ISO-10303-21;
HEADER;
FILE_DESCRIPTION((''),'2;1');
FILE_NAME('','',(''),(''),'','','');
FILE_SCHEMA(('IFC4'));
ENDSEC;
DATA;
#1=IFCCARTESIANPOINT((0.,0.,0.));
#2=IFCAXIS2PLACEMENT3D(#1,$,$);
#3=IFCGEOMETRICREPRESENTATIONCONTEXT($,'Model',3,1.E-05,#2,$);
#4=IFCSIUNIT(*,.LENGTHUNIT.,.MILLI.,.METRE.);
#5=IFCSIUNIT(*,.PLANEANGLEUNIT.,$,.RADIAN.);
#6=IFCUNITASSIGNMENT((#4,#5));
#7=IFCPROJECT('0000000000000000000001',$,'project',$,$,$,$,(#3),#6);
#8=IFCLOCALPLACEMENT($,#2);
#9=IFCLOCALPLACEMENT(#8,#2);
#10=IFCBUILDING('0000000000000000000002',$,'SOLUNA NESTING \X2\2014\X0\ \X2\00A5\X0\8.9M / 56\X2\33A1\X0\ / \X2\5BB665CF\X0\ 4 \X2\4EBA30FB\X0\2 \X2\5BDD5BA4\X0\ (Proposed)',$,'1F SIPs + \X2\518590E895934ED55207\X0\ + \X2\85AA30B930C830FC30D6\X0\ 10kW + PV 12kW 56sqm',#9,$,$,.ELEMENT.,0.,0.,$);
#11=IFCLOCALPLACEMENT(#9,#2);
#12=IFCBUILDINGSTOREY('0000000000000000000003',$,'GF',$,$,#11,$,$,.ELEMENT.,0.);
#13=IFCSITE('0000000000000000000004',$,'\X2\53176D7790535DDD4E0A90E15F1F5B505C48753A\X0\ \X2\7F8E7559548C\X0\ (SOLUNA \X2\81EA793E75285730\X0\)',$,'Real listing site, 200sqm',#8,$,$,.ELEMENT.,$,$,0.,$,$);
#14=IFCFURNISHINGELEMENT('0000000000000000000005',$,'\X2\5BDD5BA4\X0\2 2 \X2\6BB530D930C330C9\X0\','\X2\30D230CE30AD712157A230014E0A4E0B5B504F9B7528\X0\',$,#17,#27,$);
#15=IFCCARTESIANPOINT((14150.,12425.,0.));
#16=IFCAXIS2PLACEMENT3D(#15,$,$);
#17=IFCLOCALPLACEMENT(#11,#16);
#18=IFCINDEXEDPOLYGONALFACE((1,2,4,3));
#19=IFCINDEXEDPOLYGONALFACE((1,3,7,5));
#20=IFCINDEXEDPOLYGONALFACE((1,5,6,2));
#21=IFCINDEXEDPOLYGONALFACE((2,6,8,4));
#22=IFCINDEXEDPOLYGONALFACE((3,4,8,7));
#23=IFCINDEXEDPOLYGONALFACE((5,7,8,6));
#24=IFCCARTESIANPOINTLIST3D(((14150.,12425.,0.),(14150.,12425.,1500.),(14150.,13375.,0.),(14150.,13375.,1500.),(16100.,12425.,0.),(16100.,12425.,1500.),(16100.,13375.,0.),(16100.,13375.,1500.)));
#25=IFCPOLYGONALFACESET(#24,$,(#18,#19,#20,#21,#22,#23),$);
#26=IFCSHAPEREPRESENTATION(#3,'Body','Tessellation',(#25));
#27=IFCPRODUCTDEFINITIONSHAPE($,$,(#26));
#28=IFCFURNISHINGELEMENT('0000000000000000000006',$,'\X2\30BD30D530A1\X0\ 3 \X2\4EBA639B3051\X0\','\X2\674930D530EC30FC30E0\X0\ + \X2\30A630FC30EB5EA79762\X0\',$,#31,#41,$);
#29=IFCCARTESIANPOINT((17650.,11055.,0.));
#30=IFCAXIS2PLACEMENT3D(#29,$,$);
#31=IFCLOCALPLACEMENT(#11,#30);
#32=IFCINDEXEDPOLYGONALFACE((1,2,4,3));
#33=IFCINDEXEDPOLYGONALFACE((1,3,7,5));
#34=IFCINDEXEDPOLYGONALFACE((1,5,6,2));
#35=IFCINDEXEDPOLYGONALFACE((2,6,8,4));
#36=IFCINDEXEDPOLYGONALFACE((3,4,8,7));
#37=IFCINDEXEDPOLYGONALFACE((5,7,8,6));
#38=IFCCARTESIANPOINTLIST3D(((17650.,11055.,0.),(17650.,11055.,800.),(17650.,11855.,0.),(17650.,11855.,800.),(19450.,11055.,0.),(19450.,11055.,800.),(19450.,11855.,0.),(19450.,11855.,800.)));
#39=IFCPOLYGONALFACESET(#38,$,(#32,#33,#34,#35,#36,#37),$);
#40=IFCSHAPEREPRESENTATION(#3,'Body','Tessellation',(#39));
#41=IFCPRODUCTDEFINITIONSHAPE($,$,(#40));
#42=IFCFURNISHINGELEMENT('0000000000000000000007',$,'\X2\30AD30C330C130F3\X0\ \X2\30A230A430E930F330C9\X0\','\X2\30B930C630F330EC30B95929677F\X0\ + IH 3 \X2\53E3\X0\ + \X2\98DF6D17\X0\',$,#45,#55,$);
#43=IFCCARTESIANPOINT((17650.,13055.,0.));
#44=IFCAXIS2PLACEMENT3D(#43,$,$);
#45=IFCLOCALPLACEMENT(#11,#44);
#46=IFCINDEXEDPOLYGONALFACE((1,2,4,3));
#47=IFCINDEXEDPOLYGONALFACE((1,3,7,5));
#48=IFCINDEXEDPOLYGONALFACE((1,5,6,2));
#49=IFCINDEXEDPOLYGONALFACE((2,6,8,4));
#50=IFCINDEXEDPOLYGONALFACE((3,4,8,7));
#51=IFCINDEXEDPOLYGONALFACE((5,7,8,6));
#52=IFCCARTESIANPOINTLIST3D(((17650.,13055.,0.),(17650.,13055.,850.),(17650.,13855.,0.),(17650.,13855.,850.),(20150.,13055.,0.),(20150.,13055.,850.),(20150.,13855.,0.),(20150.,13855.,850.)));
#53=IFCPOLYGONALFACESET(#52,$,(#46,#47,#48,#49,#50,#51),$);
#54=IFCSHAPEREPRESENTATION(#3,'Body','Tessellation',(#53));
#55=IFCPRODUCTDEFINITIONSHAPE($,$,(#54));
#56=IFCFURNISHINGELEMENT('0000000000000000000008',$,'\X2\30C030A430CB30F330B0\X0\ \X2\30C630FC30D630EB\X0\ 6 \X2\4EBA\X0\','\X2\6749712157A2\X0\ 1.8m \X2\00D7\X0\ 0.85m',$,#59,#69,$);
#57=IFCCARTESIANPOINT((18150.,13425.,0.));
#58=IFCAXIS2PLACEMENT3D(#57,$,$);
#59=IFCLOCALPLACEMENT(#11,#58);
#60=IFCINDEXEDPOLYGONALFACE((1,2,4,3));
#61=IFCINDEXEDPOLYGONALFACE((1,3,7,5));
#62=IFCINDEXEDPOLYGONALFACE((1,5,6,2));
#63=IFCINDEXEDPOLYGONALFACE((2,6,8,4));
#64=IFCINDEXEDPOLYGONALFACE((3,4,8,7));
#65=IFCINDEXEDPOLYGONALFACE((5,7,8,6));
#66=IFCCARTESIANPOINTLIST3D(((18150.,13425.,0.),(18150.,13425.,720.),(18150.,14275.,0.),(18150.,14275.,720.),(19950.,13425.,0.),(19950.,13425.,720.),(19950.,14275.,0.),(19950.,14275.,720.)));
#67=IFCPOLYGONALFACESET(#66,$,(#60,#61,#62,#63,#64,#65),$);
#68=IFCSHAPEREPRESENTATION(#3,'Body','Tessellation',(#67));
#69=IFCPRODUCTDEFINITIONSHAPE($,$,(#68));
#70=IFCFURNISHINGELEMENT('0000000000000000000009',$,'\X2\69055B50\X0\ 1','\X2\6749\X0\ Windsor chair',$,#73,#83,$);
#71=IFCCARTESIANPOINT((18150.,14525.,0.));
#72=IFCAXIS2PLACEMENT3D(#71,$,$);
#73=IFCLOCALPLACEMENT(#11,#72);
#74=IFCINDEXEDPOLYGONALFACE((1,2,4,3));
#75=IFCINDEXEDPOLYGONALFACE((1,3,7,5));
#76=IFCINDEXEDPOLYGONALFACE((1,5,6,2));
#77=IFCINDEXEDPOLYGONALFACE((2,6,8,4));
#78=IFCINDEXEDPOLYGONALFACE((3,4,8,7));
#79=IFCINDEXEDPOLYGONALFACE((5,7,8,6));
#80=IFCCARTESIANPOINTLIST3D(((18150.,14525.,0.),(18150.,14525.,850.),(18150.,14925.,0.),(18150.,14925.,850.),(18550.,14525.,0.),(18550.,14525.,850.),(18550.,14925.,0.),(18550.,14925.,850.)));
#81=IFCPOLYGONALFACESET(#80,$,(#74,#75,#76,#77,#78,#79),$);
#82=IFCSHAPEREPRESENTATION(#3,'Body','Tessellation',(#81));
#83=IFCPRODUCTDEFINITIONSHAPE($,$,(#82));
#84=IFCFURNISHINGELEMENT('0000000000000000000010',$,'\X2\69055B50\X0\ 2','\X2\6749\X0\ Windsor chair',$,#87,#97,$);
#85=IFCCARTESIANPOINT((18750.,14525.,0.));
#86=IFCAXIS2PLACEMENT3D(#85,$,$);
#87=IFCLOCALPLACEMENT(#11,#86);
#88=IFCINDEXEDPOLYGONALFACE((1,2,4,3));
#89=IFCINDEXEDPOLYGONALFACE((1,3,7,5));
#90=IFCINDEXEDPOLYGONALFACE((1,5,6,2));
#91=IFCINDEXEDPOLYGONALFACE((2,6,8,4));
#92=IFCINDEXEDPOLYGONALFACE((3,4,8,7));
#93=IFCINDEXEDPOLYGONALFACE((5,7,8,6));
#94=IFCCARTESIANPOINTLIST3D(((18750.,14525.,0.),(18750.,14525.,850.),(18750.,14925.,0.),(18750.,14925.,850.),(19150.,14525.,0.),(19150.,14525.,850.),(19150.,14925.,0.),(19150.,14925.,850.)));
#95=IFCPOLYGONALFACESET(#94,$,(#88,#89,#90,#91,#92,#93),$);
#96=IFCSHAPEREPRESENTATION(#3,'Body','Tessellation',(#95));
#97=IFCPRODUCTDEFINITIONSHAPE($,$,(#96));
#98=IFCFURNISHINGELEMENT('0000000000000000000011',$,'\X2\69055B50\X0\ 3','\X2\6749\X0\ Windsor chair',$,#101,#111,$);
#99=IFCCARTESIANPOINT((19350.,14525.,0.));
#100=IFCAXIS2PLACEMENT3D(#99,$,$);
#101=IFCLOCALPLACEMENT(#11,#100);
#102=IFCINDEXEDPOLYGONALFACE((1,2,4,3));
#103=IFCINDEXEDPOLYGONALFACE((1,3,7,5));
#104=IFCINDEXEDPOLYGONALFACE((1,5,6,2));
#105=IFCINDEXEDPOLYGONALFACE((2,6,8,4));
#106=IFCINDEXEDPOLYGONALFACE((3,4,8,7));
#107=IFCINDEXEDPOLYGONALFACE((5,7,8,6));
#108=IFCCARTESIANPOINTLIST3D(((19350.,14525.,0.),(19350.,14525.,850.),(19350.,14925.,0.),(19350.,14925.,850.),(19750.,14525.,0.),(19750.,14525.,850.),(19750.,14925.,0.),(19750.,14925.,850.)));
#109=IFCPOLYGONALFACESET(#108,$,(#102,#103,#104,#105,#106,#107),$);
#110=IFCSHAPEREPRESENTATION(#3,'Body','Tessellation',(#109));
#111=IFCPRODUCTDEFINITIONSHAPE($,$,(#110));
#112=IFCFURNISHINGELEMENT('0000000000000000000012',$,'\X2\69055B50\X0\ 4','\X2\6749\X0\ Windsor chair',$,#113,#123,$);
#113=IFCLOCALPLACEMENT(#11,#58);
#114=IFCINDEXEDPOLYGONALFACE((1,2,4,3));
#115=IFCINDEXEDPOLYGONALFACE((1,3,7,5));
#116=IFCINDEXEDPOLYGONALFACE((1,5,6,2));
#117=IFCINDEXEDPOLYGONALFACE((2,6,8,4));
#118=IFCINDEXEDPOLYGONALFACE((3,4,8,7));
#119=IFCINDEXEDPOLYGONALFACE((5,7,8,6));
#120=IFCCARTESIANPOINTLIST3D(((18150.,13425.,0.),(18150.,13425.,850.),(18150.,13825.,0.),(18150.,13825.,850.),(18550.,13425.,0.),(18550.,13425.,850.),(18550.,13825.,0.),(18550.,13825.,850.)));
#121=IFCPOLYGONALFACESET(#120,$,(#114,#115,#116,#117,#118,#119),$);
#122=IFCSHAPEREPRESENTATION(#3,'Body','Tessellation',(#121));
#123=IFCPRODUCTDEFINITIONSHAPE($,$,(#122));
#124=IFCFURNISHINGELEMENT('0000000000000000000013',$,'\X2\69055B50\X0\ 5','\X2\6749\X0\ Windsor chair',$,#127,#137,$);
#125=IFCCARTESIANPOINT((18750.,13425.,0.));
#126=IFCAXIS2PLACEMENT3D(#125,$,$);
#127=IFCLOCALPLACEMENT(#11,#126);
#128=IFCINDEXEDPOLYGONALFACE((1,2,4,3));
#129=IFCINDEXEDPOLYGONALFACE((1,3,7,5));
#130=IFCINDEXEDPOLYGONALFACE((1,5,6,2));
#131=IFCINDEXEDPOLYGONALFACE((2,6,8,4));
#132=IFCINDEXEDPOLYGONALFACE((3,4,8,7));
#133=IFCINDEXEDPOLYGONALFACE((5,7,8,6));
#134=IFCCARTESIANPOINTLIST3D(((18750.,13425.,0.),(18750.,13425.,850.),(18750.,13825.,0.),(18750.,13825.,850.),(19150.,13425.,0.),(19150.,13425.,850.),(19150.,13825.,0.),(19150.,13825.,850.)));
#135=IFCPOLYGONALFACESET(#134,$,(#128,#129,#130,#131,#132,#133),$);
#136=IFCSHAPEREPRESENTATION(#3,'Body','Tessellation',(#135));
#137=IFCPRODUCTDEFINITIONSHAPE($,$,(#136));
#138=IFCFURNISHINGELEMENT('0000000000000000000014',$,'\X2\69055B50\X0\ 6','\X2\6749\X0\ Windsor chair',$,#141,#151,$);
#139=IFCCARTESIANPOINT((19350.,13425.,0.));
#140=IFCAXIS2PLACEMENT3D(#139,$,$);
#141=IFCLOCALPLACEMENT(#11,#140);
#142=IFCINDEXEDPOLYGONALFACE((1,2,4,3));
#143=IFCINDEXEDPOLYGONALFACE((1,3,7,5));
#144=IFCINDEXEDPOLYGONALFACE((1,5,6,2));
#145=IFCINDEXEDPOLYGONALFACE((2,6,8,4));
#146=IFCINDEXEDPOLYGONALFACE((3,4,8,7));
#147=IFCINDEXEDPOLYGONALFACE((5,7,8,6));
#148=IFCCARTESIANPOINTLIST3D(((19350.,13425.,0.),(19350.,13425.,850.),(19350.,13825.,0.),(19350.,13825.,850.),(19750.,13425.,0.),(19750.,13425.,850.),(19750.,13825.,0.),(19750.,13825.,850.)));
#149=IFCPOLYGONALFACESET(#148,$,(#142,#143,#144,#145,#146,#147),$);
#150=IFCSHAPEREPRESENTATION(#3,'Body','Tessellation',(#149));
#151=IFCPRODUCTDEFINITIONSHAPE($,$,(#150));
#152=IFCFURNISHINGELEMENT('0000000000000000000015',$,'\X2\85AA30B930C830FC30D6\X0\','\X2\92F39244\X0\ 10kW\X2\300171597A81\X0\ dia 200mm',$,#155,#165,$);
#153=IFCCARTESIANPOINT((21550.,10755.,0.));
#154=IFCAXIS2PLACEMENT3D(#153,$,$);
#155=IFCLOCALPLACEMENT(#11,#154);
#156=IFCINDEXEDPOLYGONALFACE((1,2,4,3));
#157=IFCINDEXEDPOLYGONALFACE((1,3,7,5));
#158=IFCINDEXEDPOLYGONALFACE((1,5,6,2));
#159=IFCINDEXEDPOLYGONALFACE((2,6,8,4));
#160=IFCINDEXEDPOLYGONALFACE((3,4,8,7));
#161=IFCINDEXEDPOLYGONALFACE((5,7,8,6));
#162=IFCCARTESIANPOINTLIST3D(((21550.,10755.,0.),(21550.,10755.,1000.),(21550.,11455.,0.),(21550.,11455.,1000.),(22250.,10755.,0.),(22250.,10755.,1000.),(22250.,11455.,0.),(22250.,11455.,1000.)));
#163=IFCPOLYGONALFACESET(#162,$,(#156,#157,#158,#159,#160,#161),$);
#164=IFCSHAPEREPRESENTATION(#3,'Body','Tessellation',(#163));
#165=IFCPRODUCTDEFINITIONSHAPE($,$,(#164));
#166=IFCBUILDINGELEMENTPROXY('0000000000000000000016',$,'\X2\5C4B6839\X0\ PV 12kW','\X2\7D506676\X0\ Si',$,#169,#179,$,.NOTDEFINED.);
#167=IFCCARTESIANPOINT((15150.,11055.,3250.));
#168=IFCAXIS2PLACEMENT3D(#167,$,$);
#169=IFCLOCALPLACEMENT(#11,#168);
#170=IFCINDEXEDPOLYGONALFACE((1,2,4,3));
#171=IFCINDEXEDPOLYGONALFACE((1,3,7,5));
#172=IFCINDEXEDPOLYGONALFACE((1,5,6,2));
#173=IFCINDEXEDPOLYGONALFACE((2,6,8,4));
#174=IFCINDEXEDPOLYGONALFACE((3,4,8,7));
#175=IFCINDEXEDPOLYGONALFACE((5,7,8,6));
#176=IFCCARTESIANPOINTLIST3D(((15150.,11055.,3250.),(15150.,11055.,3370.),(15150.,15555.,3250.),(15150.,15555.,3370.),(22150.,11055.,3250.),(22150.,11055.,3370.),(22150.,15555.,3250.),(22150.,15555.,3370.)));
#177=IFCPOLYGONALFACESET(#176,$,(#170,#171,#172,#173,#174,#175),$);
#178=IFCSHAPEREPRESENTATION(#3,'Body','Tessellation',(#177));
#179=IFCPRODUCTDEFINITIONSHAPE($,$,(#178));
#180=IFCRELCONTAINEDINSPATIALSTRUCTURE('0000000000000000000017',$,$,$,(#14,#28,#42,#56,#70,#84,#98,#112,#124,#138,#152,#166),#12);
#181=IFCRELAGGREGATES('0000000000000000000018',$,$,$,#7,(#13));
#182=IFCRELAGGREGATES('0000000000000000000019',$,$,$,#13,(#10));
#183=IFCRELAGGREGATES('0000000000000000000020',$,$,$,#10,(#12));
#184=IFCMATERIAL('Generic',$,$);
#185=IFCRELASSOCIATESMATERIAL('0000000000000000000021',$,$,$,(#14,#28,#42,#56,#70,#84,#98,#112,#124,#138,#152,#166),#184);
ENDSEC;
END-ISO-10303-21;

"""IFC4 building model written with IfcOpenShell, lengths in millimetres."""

from ifc_helpers import new_model, si_unit, frame, frame_2d, origin, place, context, project, spatial, rectangle, extrude, material, element, save


model = new_model("IFC4")

# Units and contexts
model_context = context("Model", 3, precision=1e-05, world=origin())
ifc_project = project(units=[si_unit("LENGTHUNIT", "METRE", prefix="MILLI"), si_unit("PLANEANGLEUNIT", "RADIAN")], contexts=[model_context])

# Site, building, storey
site_placement = place(None, origin())
site = spatial("IfcSite", under=ifc_project, at=site_placement, Name="北海道川上郡弟子屈町 美留和 (SOLUNA 自社用地)", ObjectType="Real listing site, 200sqm", CompositionType="ELEMENT", RefElevation=0.0)
building_placement = place(site_placement, origin())
building = spatial("IfcBuilding", under=site, at=building_placement, Name="SOLUNA NESTING — ¥8.9M / 56㎡ / 家族 4 人・2 寝室 (Proposed)", ObjectType="1F SIPs + 内部間仕切 + 薪ストーブ 10kW + PV 12kW 56sqm", CompositionType="ELEMENT", ElevationOfRefHeight=0.0, ElevationOfTerrain=0.0)
storey_placement = place(building_placement, origin())
storey = spatial("IfcBuildingStorey", under=building, at=storey_placement, Name="GF", CompositionType="ELEMENT", Elevation=0.0)

# Shared definitions
ifc_material = material(Name="Generic")

# Furnishing elements
furnishing_1_placement = place(storey_placement, frame((14150.0, 12425.0, 0.0)))
element("IfcFurnishingElement", 1, at=furnishing_1_placement, inside=storey, material=ifc_material, Name="寝室2 2 段ベッド", Description="ヒノキ無垢、上下子供用", context=model_context, shape_type="SweptSolid", body=[
    extrude(rectangle(XDim=1950.0, YDim=950.0, at=frame_2d((975.0, 475.0))), frame((14150.0, 12425.0, 0.0)), (0.0, 0.0, 1.0), 1500.0),
])
furnishing_2_placement = place(storey_placement, frame((17650.0, 11055.0, 0.0)))
element("IfcFurnishingElement", 2, at=furnishing_2_placement, inside=storey, material=ifc_material, Name="ソファ 3 人掛け", Description="杉フレーム + ウール座面", context=model_context, shape_type="SweptSolid", body=[
    extrude(rectangle(XDim=1800.0, YDim=800.0, at=frame_2d((900.0, 400.0))), frame((17650.0, 11055.0, 0.0)), (0.0, 0.0, 1.0), 800.0),
])
furnishing_3_placement = place(storey_placement, frame((17650.0, 13055.0, 0.0)))
element("IfcFurnishingElement", 3, at=furnishing_3_placement, inside=storey, material=ifc_material, Name="キッチン アイランド", Description="ステンレス天板 + IH 3 口 + 食洗", context=model_context, shape_type="SweptSolid", body=[
    extrude(rectangle(XDim=2500.0, YDim=800.0, at=frame_2d((1250.0, 400.0))), frame((17650.0, 13055.0, 0.0)), (0.0, 0.0, 1.0), 850.0),
])
furnishing_4_placement = place(storey_placement, frame((18150.0, 13425.0, 0.0)))
element("IfcFurnishingElement", 4, at=furnishing_4_placement, inside=storey, material=ifc_material, Name="ダイニング テーブル 6 人", Description="杉無垢 1.8m × 0.85m", context=model_context, shape_type="SweptSolid", body=[
    extrude(rectangle(XDim=1800.0, YDim=850.0, at=frame_2d((900.0, 425.0))), frame((18150.0, 13425.0, 0.0)), (0.0, 0.0, 1.0), 720.0),
])
furnishing_5_placement = place(storey_placement, frame((18150.0, 14525.0, 0.0)))
element("IfcFurnishingElement", 5, at=furnishing_5_placement, inside=storey, material=ifc_material, Name="椅子 1", Description="杉 Windsor chair", context=model_context, shape_type="SweptSolid", body=[
    extrude(rectangle(XDim=400.0, YDim=400.0, at=frame_2d((200.0, 200.0))), frame((18150.0, 14525.0, 0.0)), (0.0, 0.0, 1.0), 850.0),
])
furnishing_6_placement = place(storey_placement, frame((18750.0, 14525.0, 0.0)))
element("IfcFurnishingElement", 6, at=furnishing_6_placement, inside=storey, material=ifc_material, Name="椅子 2", Description="杉 Windsor chair", context=model_context, shape_type="SweptSolid", body=[
    extrude(rectangle(XDim=400.0, YDim=400.0, at=frame_2d((200.0, 200.0))), frame((18750.0, 14525.0, 0.0)), (0.0, 0.0, 1.0), 850.0),
])
furnishing_7_placement = place(storey_placement, frame((19350.0, 14525.0, 0.0)))
element("IfcFurnishingElement", 7, at=furnishing_7_placement, inside=storey, material=ifc_material, Name="椅子 3", Description="杉 Windsor chair", context=model_context, shape_type="SweptSolid", body=[
    extrude(rectangle(XDim=400.0, YDim=400.0, at=frame_2d((200.0, 200.0))), frame((19350.0, 14525.0, 0.0)), (0.0, 0.0, 1.0), 850.0),
])
furnishing_8_placement = place(storey_placement, frame((18150.0, 13425.0, 0.0)))
element("IfcFurnishingElement", 8, at=furnishing_8_placement, inside=storey, material=ifc_material, Name="椅子 4", Description="杉 Windsor chair", context=model_context, shape_type="SweptSolid", body=[
    extrude(rectangle(XDim=400.0, YDim=400.0, at=frame_2d((200.0, 200.0))), frame((18150.0, 13425.0, 0.0)), (0.0, 0.0, 1.0), 850.0),
])
furnishing_9_placement = place(storey_placement, frame((18750.0, 13425.0, 0.0)))
element("IfcFurnishingElement", 9, at=furnishing_9_placement, inside=storey, material=ifc_material, Name="椅子 5", Description="杉 Windsor chair", context=model_context, shape_type="SweptSolid", body=[
    extrude(rectangle(XDim=400.0, YDim=400.0, at=frame_2d((200.0, 200.0))), frame((18750.0, 13425.0, 0.0)), (0.0, 0.0, 1.0), 850.0),
])
furnishing_10_placement = place(storey_placement, frame((19350.0, 13425.0, 0.0)))
element("IfcFurnishingElement", 10, at=furnishing_10_placement, inside=storey, material=ifc_material, Name="椅子 6", Description="杉 Windsor chair", context=model_context, shape_type="SweptSolid", body=[
    extrude(rectangle(XDim=400.0, YDim=400.0, at=frame_2d((200.0, 200.0))), frame((19350.0, 13425.0, 0.0)), (0.0, 0.0, 1.0), 850.0),
])
furnishing_11_placement = place(storey_placement, frame((21550.0, 10755.0, 0.0)))
element("IfcFurnishingElement", 11, at=furnishing_11_placement, inside=storey, material=ifc_material, Name="薪ストーブ", Description="鋳鉄 10kW、煙突 dia 200mm", context=model_context, shape_type="SweptSolid", body=[
    extrude(rectangle(XDim=700.0, YDim=700.0, at=frame_2d((350.0, 350.0))), frame((21550.0, 10755.0, 0.0)), (0.0, 0.0, 1.0), 1000.0),
])

# Building element proxy
proxy_placement = place(storey_placement, frame((15150.0, 11055.0, 3250.0)))
element("IfcBuildingElementProxy", 12, at=proxy_placement, inside=storey, material=ifc_material, Name="屋根 PV 12kW", Description="結晶 Si", PredefinedType="NOTDEFINED", context=model_context, shape_type="SweptSolid", body=[
    extrude(rectangle(XDim=7000.0, YDim=4500.0, at=frame_2d((3500.0, 2250.0))), frame((15150.0, 11055.0, 3250.0)), (0.0, 0.0, 1.0), 120.0),
])

save(model, "model.ifc")
